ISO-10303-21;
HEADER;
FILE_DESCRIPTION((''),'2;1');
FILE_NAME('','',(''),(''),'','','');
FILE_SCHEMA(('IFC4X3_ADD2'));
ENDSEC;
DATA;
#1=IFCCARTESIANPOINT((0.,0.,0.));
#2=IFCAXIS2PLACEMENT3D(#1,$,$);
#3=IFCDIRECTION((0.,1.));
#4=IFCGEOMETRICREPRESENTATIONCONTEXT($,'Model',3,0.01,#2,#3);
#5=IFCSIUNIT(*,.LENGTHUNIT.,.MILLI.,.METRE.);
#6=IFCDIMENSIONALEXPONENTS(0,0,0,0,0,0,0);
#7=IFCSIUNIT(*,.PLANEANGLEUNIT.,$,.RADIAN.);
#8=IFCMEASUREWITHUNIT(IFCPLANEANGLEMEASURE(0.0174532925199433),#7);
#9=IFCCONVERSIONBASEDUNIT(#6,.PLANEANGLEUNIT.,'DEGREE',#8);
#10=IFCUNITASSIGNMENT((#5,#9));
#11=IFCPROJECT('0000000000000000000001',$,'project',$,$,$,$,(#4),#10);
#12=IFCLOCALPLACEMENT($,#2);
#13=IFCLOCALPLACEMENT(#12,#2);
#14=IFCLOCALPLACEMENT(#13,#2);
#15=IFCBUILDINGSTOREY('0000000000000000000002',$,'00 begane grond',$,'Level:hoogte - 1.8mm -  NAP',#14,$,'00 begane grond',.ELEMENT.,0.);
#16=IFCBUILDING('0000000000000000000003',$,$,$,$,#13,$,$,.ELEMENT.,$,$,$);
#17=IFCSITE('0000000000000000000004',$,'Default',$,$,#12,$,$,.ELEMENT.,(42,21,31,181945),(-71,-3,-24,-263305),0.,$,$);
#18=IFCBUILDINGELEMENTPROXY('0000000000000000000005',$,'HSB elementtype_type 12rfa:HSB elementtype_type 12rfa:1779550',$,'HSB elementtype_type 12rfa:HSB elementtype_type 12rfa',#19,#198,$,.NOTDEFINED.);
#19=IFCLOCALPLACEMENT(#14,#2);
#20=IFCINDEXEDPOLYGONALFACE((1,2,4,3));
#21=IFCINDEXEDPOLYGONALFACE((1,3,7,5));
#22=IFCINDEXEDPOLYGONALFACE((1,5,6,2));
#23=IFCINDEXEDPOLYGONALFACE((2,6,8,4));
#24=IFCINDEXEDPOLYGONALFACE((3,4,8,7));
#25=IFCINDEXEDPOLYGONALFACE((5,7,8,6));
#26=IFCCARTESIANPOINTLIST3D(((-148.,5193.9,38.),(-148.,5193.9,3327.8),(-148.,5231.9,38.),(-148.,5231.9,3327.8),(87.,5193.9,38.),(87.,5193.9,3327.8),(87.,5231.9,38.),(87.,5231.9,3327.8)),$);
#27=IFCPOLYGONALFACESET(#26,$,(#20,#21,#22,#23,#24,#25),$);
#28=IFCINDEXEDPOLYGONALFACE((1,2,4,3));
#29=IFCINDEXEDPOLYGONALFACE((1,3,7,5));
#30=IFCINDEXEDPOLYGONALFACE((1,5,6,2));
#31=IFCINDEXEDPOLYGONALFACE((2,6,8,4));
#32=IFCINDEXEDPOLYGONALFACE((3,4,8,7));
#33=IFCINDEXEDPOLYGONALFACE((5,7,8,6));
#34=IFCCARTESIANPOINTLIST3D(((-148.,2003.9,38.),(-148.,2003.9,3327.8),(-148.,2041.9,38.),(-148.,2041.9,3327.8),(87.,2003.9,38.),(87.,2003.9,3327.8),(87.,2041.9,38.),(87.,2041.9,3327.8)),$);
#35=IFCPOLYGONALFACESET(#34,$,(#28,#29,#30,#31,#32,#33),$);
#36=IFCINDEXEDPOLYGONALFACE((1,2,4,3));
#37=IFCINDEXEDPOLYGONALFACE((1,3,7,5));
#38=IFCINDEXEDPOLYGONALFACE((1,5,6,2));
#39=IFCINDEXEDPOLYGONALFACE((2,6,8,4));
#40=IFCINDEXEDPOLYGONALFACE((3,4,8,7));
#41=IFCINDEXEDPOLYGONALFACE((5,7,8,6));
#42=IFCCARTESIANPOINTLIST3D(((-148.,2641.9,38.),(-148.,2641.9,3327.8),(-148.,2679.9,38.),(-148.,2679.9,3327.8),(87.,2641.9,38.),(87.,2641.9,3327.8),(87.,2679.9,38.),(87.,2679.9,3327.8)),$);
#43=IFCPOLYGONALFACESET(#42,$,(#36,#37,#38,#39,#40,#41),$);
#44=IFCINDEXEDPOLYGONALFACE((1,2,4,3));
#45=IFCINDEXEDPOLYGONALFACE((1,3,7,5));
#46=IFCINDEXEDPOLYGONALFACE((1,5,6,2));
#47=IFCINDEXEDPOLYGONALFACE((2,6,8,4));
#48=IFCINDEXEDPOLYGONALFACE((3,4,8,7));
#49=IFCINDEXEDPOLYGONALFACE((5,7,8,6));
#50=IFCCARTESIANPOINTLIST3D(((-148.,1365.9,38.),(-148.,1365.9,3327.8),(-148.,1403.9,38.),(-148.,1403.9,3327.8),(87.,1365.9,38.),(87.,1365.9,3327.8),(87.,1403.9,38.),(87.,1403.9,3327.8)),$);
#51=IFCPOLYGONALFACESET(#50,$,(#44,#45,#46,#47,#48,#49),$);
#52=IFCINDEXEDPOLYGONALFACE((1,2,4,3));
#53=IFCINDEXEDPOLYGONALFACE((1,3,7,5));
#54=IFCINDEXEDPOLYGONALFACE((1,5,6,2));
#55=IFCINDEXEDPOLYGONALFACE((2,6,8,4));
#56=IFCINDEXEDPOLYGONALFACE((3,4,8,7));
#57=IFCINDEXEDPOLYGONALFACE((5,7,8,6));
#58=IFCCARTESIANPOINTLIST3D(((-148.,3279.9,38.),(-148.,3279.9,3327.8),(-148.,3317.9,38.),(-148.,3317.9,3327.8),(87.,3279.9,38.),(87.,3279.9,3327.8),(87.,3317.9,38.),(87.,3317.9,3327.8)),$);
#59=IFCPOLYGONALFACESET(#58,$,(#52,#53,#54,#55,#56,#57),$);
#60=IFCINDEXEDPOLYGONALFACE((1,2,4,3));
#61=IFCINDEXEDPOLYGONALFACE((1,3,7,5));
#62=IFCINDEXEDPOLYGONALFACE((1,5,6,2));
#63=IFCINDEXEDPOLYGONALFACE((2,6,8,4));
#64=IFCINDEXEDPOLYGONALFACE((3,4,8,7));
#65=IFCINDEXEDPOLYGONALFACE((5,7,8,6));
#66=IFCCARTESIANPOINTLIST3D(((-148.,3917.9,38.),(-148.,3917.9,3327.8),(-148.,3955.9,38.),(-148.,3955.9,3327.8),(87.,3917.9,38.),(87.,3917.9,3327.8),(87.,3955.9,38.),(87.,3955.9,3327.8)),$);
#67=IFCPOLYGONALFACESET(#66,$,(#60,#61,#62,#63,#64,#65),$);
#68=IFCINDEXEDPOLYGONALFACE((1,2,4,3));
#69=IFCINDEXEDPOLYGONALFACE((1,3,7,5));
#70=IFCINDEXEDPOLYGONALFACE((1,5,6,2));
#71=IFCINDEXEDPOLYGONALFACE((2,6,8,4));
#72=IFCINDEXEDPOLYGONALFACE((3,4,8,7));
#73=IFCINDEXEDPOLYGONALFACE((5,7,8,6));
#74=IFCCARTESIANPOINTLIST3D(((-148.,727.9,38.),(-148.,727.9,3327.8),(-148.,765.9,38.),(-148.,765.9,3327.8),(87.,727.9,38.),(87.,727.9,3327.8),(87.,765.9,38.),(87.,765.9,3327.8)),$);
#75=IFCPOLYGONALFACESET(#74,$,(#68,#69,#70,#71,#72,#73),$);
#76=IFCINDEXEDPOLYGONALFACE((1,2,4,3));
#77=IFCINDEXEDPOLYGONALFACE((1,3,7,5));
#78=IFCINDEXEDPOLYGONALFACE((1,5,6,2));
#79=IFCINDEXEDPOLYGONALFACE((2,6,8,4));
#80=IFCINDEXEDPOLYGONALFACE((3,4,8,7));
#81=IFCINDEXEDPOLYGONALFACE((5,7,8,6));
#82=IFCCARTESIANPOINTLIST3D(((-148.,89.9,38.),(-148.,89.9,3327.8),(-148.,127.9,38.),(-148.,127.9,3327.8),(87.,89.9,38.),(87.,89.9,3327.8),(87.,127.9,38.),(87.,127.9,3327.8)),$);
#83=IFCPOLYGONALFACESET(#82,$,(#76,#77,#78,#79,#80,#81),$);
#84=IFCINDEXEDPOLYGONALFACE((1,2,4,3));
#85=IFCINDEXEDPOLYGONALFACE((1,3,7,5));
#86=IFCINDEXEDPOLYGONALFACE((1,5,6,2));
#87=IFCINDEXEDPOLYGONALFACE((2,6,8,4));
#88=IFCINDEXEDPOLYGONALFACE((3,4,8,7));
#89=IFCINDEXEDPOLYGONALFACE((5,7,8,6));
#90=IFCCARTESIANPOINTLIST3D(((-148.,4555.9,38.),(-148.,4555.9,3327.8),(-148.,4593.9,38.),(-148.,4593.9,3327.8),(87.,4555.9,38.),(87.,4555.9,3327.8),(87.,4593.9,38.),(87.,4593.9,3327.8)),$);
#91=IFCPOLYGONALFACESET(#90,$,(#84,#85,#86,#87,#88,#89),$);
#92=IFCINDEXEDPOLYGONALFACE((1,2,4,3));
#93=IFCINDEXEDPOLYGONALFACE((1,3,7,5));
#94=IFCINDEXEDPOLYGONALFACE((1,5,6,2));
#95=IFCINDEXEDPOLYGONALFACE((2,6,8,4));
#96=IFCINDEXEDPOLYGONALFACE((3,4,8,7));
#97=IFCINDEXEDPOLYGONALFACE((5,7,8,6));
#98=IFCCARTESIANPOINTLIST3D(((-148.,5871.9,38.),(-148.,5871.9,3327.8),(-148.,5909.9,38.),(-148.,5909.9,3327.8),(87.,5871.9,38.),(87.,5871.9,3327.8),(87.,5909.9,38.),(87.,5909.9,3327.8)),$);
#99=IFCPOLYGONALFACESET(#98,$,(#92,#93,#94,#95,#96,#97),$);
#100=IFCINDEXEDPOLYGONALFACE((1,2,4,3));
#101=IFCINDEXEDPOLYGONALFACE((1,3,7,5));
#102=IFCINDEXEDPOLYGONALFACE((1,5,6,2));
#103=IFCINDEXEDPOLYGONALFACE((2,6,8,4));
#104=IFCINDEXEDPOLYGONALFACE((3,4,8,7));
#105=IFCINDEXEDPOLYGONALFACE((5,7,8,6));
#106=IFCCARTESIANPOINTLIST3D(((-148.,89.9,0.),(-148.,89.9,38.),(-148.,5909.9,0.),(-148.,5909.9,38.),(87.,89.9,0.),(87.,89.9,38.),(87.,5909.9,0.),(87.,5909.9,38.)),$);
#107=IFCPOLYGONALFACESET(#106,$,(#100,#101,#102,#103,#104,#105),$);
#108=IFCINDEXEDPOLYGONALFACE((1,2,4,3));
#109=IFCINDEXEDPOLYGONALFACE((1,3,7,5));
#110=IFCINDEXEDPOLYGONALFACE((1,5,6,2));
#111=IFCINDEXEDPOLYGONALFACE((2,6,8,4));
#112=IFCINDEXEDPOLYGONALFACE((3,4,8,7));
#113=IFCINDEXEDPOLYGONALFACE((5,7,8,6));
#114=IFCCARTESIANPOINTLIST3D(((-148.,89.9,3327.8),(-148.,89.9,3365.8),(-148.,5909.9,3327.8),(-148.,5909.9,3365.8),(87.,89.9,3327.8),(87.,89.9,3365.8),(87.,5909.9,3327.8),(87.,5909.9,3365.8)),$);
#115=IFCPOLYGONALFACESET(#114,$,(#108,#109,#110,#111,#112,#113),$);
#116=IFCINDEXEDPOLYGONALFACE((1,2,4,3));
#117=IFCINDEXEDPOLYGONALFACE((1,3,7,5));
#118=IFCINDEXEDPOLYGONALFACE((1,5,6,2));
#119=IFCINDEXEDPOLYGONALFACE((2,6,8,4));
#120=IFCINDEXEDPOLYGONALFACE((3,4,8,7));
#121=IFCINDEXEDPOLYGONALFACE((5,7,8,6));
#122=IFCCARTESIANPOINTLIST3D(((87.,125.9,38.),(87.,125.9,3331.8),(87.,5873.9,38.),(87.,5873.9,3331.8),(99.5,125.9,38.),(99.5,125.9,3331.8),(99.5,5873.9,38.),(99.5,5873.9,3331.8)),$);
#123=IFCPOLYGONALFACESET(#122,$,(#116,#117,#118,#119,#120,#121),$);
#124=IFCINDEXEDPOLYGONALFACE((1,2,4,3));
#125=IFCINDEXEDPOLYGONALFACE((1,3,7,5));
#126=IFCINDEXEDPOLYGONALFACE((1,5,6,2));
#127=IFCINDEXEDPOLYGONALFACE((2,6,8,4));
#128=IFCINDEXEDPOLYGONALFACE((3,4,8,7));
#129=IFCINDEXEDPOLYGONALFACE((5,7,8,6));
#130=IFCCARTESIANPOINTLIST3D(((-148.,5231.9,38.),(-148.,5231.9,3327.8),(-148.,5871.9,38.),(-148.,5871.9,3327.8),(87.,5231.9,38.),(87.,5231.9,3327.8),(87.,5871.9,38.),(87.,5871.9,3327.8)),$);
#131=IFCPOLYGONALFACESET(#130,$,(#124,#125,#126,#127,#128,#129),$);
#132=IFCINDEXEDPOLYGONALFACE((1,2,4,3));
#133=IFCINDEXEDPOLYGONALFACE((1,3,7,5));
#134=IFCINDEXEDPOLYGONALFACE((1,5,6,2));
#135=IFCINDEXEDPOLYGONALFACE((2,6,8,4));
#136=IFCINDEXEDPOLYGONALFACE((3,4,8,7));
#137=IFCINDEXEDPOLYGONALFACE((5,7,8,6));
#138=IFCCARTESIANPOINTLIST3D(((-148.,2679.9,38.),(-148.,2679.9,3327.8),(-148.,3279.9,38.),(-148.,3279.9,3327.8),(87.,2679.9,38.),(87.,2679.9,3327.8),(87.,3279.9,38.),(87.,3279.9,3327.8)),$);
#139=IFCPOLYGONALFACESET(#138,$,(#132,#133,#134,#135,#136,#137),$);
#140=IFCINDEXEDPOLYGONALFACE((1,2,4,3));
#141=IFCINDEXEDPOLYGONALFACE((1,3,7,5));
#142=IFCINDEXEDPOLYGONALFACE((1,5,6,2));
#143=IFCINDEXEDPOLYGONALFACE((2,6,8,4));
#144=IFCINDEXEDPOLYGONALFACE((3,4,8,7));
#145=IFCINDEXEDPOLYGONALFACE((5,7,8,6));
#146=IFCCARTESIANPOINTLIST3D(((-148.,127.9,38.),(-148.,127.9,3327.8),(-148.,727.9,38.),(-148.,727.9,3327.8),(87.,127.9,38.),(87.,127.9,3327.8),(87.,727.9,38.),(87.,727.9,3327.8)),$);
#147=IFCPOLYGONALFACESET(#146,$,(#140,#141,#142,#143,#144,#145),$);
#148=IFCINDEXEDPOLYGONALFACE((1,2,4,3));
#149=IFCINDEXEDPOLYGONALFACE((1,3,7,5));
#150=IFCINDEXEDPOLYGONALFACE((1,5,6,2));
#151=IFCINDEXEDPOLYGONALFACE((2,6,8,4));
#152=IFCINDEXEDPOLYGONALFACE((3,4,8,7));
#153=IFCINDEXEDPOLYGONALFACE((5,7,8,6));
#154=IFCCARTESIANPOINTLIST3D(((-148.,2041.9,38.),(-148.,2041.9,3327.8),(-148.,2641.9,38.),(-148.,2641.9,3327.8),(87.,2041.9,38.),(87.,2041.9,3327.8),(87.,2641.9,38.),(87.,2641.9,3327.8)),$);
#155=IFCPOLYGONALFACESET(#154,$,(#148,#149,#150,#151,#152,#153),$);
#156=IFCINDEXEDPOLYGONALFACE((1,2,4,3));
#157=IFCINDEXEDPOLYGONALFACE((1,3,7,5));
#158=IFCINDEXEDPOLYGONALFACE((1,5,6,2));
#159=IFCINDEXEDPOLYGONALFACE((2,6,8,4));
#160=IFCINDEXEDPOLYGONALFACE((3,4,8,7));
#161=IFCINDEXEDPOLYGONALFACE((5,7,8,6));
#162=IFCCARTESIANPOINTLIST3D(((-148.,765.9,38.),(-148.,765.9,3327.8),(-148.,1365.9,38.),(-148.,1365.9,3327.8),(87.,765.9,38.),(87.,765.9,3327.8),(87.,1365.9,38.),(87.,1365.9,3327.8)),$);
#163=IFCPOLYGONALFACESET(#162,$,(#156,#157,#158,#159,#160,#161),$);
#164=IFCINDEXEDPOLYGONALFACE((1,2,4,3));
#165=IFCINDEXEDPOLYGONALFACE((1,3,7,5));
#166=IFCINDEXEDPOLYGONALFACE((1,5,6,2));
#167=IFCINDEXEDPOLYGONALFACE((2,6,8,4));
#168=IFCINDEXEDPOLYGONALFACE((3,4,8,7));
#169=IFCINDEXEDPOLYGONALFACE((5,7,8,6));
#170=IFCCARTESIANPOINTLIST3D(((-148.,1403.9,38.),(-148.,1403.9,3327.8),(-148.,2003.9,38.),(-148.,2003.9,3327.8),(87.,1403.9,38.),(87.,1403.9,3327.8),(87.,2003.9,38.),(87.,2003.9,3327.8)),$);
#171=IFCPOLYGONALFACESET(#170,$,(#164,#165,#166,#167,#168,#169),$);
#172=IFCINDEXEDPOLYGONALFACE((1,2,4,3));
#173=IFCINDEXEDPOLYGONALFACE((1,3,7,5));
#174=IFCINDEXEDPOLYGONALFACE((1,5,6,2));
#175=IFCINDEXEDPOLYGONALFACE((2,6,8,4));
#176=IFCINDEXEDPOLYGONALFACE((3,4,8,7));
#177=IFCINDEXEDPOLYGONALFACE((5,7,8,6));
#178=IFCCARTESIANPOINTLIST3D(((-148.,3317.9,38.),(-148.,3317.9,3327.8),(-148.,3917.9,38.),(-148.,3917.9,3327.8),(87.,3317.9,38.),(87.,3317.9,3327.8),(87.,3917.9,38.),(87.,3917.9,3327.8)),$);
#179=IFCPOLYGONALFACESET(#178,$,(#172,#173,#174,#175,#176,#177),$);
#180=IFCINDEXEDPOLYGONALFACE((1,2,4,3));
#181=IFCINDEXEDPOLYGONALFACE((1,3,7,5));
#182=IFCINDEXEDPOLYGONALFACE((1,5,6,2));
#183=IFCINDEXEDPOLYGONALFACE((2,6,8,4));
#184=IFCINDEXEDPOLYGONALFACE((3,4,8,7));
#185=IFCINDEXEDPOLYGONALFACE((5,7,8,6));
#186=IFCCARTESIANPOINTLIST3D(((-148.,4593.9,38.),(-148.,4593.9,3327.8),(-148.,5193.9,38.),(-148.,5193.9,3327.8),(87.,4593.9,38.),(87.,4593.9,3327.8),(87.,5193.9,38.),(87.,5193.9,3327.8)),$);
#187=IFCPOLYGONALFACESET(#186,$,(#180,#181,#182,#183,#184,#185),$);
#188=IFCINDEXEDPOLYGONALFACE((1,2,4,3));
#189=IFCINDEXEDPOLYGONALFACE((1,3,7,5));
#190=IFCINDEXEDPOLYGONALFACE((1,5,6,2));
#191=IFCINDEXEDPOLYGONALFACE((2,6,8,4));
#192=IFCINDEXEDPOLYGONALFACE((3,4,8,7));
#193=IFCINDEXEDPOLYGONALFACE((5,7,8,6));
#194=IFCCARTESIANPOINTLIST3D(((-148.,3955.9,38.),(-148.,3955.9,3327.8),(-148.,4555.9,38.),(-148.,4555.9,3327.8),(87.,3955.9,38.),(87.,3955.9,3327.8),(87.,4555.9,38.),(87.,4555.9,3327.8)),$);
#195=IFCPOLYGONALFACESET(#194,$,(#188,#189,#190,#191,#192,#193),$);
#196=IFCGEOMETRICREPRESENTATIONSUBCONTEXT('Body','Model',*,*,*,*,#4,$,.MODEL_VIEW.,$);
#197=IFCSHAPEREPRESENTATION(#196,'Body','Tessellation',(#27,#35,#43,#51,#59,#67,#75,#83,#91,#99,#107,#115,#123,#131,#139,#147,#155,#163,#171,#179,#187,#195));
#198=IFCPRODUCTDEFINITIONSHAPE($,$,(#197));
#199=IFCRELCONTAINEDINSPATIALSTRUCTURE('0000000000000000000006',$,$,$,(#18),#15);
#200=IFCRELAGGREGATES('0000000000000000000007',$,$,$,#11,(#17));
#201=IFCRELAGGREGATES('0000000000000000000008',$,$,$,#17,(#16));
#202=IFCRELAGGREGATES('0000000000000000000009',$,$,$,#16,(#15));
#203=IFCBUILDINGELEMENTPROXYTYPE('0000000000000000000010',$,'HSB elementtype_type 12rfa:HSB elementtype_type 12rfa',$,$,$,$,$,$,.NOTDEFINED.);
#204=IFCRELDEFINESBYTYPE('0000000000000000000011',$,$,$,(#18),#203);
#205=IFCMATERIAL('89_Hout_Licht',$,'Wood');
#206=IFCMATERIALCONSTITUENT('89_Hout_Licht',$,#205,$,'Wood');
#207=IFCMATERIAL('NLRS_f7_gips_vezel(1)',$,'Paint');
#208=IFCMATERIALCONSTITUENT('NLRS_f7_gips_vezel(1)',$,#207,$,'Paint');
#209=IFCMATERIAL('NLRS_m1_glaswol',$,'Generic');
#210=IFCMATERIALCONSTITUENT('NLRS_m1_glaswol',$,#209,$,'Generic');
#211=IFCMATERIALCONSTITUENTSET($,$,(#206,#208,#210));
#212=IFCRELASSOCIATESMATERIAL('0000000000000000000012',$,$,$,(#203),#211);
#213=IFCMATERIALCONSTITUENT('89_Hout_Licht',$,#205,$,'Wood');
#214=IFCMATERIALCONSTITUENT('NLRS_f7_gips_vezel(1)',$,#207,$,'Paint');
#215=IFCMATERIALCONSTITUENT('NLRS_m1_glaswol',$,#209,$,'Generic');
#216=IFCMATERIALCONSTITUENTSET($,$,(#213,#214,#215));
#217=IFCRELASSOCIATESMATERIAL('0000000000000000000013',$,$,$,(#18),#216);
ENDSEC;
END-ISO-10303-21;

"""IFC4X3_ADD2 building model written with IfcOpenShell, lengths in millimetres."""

from ifc_helpers import new_model, entity, si_unit, converted_unit, direction, frame, frame_2d, origin, origin_2d_with_axis, place, context, subcontext, project, spatial, rectangle, extrude, source, transform, mapped, material, constituent, constituent_set, type_object, type_shapes, element, save


model = new_model("IFC4X3_ADD2")

# Units and contexts
model_context = context("Model", 3, precision=0.01, world=origin(), true_north=direction((0.0, 1.0)))
body_context = subcontext(model_context, "Body", "Model", "MODEL_VIEW")
ifc_project = project(units=[si_unit("LENGTHUNIT", "METRE", prefix="MILLI"), converted_unit("PLANEANGLEUNIT", "DEGREE", entity("IfcPlaneAngleMeasure", 0.0174532925199433), si_unit("PLANEANGLEUNIT", "RADIAN"), dimensions=[0, 0, 0, 0, 0, 0, 0])], contexts=[model_context])

# Site, building, storey
site_placement = place(None, origin())
site = spatial("IfcSite", under=ifc_project, at=site_placement, Name="Default", CompositionType="ELEMENT", RefLatitude=(42, 21, 31, 181945), RefLongitude=(-71, -3, -24, -263305), RefElevation=0.0)
building_placement = place(site_placement, origin())
building = spatial("IfcBuilding", under=site, at=building_placement, CompositionType="ELEMENT")
storey_placement = place(building_placement, origin())
storey = spatial("IfcBuildingStorey", under=building, at=storey_placement, Name="00 begane grond", ObjectType="Level:hoogte - 1.8mm -  NAP", LongName="00 begane grond", CompositionType="ELEMENT", Elevation=0.0)

# Shared definitions
ifc_material_1 = material(Name="NLRS_m1_glaswol", Category="Generic")

# Shared definitions
ifc_material_2 = material(Name="NLRS_f7_gips_vezel(1)", Category="Paint")

# Building element proxy
ifc_material_3 = material(Name="89_Hout_Licht", Category="Wood")
ifc_constituent_1 = constituent(ifc_material_3, Name="89_Hout_Licht", Category="Wood")
ifc_constituent_2 = constituent(ifc_material_2, Name="NLRS_f7_gips_vezel(1)", Category="Paint")
ifc_constituent_3 = constituent(ifc_material_1, Name="NLRS_m1_glaswol", Category="Generic")
ifc_constituent_set_1 = constituent_set(constituents=[ifc_constituent_1, ifc_constituent_2, ifc_constituent_3])
ifc_constituent_4 = constituent(ifc_material_3, Name="89_Hout_Licht", Category="Wood")
ifc_constituent_5 = constituent(ifc_material_2, Name="NLRS_f7_gips_vezel(1)", Category="Paint")
ifc_constituent_6 = constituent(ifc_material_1, Name="NLRS_m1_glaswol", Category="Generic")
ifc_constituent_set_2 = constituent_set(constituents=[ifc_constituent_4, ifc_constituent_5, ifc_constituent_6])
building_element_proxy_type_1 = type_object("IfcBuildingElementProxyType", Name="HSB elementtype_type 12rfa:HSB elementtype_type 12rfa", PredefinedType="NOTDEFINED", material=ifc_constituent_set_2)
shared_shape_1 = source(origin(), body_context, "Body", "SweptSolid", [
    extrude(rectangle(XDim=235.0, YDim=38.0, at=origin_2d_with_axis()), frame((-30.5, 5212.9, 38.0)), (0.0, 0.0, 1.0), 3289.8),
    extrude(rectangle(XDim=235.0, YDim=38.0, at=origin_2d_with_axis()), frame((-30.5, 2022.9, 38.0)), (0.0, 0.0, 1.0), 3289.8),
    extrude(rectangle(XDim=235.0, YDim=38.0, at=origin_2d_with_axis()), frame((-30.5, 2660.9, 38.0)), (0.0, 0.0, 1.0), 3289.8),
    extrude(rectangle(XDim=235.0, YDim=38.0, at=frame_2d((0.0, 0.0), x_axis=(1.0, 0.0))), frame((-30.5, 1384.9, 38.0)), (0.0, 0.0, 1.0), 3289.8),
    extrude(rectangle(XDim=235.0, YDim=38.0, at=origin_2d_with_axis()), frame((-30.5, 3298.9, 38.0)), (0.0, 0.0, 1.0), 3289.8),
    extrude(rectangle(XDim=235.0, YDim=38.0, at=origin_2d_with_axis()), frame((-30.5, 3936.9, 38.0)), (0.0, 0.0, 1.0), 3289.8),
    extrude(rectangle(XDim=235.0, YDim=38.0, at=origin_2d_with_axis()), frame((-30.5, 746.9, 38.0)), (0.0, 0.0, 1.0), 3289.8),
    extrude(rectangle(XDim=235.0, YDim=38.0, at=frame_2d((0.0, 0.0), x_axis=(1.0, 0.0))), frame((-30.5, 108.9, 38.0)), (0.0, 0.0, 1.0), 3289.8),
    extrude(rectangle(XDim=235.0, YDim=38.0, at=origin_2d_with_axis()), frame((-30.5, 4574.9, 38.0)), (0.0, 0.0, 1.0), 3289.8),
    extrude(rectangle(XDim=235.0, YDim=38.0, at=origin_2d_with_axis()), frame((-30.5, 5890.9, 38.0)), (0.0, 0.0, 1.0), 3289.8),
    extrude(rectangle(XDim=235.0, YDim=5820.0, at=frame_2d((-23.5, -574.8), x_axis=(1.0, 0.0))), frame((-7.0, 3574.7, 0.0)), (0.0, 0.0, 1.0), 38.0),
    extrude(rectangle(XDim=235.0, YDim=5820.0, at=frame_2d((0.0, 0.0), x_axis=(1.0, 0.0))), frame((-30.5, 2999.9, 3327.8)), (0.0, 0.0, 1.0), 38.0),
    extrude(rectangle(XDim=12.5, YDim=5748.0, at=frame_2d((0.0, 0.0), x_axis=(1.0, 0.0))), frame((93.2, 2999.9, 38.0)), (0.0, 0.0, 1.0), 3293.8),
    extrude(rectangle(XDim=235.0, YDim=640.0, at=origin_2d_with_axis()), frame((-30.5, 5551.9, 38.0)), (0.0, 0.0, 1.0), 3289.8),
    extrude(rectangle(XDim=235.0, YDim=600.0, at=frame_2d((0.0, 0.0), x_axis=(1.0, 0.0))), frame((-30.5, 2979.9, 38.0)), (0.0, 0.0, 1.0), 3289.8),
    extrude(rectangle(XDim=235.0, YDim=600.0, at=frame_2d((0.0, 0.0), x_axis=(1.0, 0.0))), frame((-30.5, 427.9, 38.0)), (0.0, 0.0, 1.0), 3289.8),
    extrude(rectangle(XDim=235.0, YDim=600.0, at=frame_2d((0.0, 0.0), x_axis=(1.0, 0.0))), frame((-30.5, 2341.9, 38.0)), (0.0, 0.0, 1.0), 3289.8),
    extrude(rectangle(XDim=235.0, YDim=600.0, at=frame_2d((0.0, 0.0), x_axis=(1.0, 0.0))), frame((-30.5, 1065.9, 38.0)), (0.0, 0.0, 1.0), 3289.8),
    extrude(rectangle(XDim=235.0, YDim=600.0, at=frame_2d((0.0, 0.0), x_axis=(1.0, 0.0))), frame((-30.5, 1703.9, 38.0)), (0.0, 0.0, 1.0), 3289.8),
    extrude(rectangle(XDim=235.0, YDim=600.0, at=origin_2d_with_axis()), frame((-30.5, 3617.9, 38.0)), (0.0, 0.0, 1.0), 3289.8),
    extrude(rectangle(XDim=235.0, YDim=600.0, at=frame_2d((0.0, 0.0), x_axis=(1.0, 0.0))), frame((-30.5, 4893.9, 38.0)), (0.0, 0.0, 1.0), 3289.8),
    extrude(rectangle(XDim=235.0, YDim=600.0, at=frame_2d((0.0, 0.0), x_axis=(1.0, 0.0))), frame((-30.5, 4255.9, 38.0)), (0.0, 0.0, 1.0), 3289.8),
])
type_shapes(building_element_proxy_type_1, [shared_shape_1])
proxy_1_placement = place(storey_placement, origin())
element("IfcBuildingElementProxy", 1, at=proxy_1_placement, inside=storey, type_object=building_element_proxy_type_1, material=ifc_constituent_set_1, Name="HSB elementtype_type 12rfa:HSB elementtype_type 12rfa:1779550", ObjectType="HSB elementtype_type 12rfa:HSB elementtype_type 12rfa", PredefinedType="NOTDEFINED", context=body_context, shape_type="MappedRepresentation", body=[
    mapped(shared_shape_1, transform((0.0, 0.0, 0.0), scale=1.0)),
])

save(model, "model.ifc")
